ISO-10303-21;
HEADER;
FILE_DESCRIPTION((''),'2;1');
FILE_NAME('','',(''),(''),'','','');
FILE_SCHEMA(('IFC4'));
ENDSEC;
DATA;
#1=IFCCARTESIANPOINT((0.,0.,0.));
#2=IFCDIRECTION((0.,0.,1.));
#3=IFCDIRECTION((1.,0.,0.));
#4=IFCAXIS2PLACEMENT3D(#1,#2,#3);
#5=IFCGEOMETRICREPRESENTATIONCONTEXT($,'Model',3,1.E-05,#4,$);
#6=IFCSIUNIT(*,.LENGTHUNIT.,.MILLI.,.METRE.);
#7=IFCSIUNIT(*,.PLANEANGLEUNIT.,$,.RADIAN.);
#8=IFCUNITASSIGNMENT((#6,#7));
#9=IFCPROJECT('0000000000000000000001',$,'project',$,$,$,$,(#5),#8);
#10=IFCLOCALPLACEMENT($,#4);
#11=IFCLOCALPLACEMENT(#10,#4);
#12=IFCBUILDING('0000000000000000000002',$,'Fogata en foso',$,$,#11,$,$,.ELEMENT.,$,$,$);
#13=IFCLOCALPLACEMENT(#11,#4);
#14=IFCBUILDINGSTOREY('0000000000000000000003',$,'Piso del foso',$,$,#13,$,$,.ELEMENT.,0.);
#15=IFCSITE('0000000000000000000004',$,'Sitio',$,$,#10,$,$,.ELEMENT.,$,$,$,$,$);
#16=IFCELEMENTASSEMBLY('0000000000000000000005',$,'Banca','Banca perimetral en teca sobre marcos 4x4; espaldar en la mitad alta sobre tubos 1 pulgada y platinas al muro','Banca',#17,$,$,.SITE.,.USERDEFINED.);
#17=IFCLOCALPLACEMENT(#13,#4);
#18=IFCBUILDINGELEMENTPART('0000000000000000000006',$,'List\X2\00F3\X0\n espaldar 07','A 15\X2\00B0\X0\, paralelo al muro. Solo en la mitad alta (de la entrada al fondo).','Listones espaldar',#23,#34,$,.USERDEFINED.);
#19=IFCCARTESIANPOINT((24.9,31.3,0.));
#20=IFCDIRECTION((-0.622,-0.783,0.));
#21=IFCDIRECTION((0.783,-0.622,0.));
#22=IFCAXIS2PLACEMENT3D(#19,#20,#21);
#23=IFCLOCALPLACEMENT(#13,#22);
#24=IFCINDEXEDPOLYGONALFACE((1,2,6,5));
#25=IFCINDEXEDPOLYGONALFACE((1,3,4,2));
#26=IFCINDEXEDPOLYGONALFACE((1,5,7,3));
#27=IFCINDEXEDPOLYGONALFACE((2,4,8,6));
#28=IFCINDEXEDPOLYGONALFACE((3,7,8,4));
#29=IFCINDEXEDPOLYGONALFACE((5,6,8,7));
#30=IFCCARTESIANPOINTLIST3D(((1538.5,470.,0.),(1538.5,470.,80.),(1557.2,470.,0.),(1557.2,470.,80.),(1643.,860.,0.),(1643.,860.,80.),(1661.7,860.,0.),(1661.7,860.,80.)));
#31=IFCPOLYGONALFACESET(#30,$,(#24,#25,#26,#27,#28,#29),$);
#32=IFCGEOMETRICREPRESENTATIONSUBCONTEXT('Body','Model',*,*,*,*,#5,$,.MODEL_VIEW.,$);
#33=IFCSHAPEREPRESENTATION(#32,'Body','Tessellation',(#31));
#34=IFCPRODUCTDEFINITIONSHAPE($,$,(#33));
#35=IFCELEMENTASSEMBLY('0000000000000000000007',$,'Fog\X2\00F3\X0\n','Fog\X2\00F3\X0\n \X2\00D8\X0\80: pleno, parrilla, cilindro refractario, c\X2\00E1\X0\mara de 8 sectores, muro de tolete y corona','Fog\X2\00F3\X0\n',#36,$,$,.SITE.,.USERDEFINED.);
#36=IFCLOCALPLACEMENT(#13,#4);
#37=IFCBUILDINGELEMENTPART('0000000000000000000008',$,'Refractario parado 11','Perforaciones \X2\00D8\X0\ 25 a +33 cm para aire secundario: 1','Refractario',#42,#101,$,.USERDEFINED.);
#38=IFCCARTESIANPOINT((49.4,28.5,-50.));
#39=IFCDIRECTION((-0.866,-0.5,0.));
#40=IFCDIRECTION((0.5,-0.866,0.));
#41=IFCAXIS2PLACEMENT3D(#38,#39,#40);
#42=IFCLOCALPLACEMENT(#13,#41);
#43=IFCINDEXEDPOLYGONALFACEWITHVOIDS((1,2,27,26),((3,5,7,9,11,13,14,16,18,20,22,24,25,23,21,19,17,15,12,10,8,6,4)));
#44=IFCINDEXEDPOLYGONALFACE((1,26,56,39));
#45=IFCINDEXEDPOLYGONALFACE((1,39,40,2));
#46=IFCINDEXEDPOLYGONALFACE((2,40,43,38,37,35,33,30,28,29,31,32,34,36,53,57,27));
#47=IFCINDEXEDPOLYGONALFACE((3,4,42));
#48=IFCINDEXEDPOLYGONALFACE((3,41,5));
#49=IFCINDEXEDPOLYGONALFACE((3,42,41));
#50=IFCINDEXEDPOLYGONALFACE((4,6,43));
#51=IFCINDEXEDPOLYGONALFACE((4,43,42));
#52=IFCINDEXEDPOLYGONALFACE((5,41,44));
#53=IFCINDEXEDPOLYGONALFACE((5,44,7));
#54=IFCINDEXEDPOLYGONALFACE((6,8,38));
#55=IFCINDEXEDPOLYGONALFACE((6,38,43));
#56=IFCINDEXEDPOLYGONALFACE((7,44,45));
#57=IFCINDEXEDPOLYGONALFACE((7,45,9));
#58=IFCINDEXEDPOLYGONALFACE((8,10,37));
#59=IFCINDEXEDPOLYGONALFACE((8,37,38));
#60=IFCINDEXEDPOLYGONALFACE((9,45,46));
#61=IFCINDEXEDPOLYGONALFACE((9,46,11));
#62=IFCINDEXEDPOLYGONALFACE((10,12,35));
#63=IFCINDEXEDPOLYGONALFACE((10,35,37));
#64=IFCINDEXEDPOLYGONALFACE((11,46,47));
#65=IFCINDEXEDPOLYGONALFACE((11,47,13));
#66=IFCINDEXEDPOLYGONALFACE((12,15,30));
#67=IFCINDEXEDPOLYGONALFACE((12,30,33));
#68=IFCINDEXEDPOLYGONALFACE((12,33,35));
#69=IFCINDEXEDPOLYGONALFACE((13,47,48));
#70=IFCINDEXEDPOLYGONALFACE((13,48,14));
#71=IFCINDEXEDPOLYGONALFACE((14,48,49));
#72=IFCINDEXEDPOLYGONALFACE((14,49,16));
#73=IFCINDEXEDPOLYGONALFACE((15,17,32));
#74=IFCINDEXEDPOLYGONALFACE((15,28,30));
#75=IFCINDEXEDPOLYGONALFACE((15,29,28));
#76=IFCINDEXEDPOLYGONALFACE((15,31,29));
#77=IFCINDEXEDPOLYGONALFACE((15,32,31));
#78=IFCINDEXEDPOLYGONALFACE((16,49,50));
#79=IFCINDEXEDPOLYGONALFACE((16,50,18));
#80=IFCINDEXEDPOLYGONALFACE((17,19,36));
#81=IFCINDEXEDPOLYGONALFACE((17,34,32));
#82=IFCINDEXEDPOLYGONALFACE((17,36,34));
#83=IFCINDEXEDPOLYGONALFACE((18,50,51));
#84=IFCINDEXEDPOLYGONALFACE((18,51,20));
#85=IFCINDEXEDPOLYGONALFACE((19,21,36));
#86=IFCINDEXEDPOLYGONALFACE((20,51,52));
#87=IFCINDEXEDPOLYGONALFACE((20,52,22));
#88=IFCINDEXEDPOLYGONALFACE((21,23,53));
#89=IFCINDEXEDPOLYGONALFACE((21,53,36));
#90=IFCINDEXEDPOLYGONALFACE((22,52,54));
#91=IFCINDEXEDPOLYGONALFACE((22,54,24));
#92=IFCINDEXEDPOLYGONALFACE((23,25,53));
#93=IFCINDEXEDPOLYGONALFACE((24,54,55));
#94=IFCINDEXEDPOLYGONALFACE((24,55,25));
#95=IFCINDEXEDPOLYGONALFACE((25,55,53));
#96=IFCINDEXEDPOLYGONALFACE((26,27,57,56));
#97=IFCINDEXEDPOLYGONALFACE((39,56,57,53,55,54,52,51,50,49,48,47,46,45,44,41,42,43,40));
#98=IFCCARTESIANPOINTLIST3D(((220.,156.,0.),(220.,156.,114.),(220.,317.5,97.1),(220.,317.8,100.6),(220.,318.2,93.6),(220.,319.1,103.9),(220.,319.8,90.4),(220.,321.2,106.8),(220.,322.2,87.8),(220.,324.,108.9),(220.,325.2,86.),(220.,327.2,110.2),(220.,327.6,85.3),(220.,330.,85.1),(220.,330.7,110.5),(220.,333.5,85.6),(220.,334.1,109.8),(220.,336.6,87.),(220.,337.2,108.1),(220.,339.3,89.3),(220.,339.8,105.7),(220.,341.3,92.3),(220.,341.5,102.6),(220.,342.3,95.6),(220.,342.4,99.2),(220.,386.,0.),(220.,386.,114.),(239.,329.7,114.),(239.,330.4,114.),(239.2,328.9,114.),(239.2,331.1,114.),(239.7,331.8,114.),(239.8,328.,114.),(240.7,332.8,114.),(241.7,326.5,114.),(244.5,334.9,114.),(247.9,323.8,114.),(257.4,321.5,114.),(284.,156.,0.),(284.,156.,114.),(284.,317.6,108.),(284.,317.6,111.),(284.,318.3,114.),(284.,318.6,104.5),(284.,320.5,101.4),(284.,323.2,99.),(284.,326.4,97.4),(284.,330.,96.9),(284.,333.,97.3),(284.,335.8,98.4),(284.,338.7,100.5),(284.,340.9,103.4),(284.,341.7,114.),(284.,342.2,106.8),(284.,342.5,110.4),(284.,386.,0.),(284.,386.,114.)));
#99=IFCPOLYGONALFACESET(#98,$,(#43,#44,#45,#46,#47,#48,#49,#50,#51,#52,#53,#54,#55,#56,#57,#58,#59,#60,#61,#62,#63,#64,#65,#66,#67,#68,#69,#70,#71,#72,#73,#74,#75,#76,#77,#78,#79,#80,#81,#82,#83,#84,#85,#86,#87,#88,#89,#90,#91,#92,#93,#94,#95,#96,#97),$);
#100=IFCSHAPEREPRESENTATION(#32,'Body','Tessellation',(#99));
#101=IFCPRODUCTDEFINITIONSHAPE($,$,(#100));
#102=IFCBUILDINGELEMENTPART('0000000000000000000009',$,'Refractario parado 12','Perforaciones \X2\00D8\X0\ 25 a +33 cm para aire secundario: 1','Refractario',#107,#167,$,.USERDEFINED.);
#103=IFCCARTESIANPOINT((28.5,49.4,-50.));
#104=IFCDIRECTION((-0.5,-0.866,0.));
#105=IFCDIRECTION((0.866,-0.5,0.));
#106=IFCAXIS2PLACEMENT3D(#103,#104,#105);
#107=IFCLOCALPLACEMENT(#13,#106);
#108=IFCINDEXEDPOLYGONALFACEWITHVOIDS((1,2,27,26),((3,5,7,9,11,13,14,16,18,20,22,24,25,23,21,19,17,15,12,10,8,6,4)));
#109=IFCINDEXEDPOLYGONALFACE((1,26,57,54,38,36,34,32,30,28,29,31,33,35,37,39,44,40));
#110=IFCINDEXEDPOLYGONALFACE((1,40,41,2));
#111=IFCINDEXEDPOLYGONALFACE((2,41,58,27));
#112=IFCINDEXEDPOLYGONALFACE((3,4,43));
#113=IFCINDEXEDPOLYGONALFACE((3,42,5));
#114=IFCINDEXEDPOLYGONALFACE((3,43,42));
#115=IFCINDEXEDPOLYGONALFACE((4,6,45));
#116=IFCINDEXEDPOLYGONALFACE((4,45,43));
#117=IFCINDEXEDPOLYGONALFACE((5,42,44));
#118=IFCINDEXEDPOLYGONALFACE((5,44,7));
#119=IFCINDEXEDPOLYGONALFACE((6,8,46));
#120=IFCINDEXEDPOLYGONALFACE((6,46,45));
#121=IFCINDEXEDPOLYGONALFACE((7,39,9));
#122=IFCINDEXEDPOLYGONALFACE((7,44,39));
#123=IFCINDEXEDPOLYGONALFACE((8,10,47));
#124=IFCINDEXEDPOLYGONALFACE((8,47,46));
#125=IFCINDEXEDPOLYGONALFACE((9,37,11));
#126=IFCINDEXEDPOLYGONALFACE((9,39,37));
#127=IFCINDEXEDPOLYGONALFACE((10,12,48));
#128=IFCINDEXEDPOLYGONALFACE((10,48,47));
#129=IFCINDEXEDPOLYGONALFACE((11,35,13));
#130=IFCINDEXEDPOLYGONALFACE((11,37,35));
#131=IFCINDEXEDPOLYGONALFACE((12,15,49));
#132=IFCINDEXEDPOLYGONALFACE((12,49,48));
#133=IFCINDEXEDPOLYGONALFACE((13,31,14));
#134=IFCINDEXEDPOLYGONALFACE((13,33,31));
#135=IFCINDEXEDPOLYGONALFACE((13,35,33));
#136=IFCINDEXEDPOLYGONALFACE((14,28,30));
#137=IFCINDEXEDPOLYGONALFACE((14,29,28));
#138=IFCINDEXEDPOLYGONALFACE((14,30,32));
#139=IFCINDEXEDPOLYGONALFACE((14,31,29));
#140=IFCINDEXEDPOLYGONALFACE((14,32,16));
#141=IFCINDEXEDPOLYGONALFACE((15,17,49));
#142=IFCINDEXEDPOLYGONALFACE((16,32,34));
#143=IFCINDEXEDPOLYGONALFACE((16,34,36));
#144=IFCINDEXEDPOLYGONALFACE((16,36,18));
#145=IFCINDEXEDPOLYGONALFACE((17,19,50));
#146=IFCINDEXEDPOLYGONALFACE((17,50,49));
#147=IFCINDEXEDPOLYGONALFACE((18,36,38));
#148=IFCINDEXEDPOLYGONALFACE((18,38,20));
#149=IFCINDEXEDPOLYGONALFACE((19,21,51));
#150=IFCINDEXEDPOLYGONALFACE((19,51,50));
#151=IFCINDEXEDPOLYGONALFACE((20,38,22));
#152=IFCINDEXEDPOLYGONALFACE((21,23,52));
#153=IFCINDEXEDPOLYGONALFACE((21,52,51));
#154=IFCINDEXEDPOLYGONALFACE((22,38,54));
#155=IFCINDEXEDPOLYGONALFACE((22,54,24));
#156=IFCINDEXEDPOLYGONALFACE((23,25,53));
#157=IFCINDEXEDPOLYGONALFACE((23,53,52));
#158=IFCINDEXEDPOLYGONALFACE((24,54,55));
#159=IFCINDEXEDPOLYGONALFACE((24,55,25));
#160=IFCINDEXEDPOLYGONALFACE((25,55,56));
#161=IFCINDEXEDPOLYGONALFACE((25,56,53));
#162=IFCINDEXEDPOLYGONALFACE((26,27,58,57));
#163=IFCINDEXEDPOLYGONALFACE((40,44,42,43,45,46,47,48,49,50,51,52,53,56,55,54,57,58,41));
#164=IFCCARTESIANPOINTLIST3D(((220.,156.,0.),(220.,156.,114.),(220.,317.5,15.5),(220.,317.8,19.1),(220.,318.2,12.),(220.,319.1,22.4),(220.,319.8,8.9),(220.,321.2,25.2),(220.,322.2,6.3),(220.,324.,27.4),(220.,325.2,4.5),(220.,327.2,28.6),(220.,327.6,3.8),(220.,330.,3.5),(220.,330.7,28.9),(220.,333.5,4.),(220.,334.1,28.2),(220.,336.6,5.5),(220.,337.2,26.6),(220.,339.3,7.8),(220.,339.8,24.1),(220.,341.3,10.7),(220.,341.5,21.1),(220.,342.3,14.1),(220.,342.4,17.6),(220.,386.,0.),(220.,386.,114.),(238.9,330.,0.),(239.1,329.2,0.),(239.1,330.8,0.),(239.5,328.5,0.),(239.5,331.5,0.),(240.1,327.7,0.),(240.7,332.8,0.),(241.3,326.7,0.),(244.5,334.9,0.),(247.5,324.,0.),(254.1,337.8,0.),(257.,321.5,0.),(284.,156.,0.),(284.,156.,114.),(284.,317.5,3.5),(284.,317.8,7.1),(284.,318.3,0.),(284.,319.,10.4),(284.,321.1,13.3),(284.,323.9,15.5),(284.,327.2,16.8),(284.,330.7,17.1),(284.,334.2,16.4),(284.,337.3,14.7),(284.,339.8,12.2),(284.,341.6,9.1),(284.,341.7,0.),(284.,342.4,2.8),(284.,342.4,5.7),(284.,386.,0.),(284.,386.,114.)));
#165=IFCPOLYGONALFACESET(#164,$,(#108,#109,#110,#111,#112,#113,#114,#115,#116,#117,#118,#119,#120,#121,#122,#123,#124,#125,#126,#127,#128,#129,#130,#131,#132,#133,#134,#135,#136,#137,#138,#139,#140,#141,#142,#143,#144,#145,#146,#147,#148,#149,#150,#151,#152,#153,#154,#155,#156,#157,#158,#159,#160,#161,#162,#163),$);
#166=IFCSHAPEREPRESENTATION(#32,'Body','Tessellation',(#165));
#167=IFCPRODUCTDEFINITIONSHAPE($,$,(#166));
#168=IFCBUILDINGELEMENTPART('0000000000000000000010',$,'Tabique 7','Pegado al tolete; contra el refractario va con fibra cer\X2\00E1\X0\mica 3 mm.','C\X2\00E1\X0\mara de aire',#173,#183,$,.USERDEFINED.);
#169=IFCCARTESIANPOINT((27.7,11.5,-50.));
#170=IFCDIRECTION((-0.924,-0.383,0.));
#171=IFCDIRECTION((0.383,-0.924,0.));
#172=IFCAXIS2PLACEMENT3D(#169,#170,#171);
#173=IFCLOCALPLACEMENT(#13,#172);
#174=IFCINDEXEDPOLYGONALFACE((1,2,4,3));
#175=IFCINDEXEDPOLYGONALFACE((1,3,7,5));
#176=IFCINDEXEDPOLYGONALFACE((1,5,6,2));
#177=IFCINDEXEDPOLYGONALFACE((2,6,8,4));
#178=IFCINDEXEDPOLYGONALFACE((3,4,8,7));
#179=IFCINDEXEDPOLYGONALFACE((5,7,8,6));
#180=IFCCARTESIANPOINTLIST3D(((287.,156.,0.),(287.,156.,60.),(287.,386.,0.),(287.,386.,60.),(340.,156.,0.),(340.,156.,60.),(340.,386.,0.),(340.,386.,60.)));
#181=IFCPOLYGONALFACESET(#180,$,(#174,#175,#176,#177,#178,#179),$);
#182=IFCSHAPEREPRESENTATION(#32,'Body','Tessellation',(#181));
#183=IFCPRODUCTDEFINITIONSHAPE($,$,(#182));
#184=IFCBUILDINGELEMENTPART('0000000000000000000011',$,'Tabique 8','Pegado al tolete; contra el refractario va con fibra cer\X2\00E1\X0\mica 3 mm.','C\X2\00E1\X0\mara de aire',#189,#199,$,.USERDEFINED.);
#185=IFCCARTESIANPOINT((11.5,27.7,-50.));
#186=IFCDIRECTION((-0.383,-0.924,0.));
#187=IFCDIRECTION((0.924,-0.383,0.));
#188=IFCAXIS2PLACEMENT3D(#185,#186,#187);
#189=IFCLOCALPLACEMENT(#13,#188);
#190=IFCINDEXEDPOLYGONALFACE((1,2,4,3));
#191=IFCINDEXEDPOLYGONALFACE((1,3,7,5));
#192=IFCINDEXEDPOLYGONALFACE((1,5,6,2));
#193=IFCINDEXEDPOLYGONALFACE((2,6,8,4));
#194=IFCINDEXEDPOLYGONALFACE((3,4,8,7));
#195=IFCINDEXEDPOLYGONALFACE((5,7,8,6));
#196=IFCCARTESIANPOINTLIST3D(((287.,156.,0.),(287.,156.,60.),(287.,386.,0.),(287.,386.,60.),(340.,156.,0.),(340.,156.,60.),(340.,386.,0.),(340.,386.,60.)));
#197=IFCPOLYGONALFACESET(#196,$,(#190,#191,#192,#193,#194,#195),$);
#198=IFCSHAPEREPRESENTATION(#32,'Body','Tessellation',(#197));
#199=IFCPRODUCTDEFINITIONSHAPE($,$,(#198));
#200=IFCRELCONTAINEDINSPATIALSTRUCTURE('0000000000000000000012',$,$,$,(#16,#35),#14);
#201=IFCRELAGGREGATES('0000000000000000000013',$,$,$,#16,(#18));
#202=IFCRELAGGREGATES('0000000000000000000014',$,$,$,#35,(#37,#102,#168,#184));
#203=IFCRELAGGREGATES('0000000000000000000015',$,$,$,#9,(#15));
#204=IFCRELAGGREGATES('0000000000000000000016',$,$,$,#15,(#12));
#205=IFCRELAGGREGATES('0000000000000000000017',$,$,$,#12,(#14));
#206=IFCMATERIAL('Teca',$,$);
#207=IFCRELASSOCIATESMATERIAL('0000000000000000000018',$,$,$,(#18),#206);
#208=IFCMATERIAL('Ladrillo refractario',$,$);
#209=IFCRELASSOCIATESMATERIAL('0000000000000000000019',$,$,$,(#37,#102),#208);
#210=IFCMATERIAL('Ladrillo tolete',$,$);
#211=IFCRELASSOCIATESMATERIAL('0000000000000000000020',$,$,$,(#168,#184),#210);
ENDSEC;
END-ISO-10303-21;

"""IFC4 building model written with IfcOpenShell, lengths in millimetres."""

from ifc_helpers import new_model, si_unit, frame, origin_with_axes, origin_2d, place, context, subcontext, project, spatial, polyline, circle, outline, extrude, material, element, aggregate, save


model = new_model("IFC4")

# Units and contexts
model_context = context("Model", 3, precision=1e-05, world=origin_with_axes())
body_context = subcontext(model_context, "Body", "Model", "MODEL_VIEW")
ifc_project = project(units=[si_unit("LENGTHUNIT", "METRE", prefix="MILLI"), si_unit("PLANEANGLEUNIT", "RADIAN")], contexts=[model_context])

# Site, building, storey
site_placement = place(None, origin_with_axes())
site = spatial("IfcSite", under=ifc_project, at=site_placement, Name="Sitio", CompositionType="ELEMENT")
building_placement = place(site_placement, origin_with_axes())
building = spatial("IfcBuilding", under=site, at=building_placement, Name="Fogata en foso", CompositionType="ELEMENT")
storey_placement = place(building_placement, origin_with_axes())
storey = spatial("IfcBuildingStorey", under=building, at=storey_placement, Name="Piso del foso", CompositionType="ELEMENT", Elevation=0.0)

# Element assembly
assembly_1_placement = place(storey_placement, origin_with_axes())
assembly_1 = element("IfcElementAssembly", 1, at=assembly_1_placement, inside=storey, Name="Banca", Description="Banca perimetral en teca sobre marcos 4x4; espaldar en la mitad alta sobre tubos 1 pulgada y platinas al muro", ObjectType="Banca", AssemblyPlace="SITE", PredefinedType="USERDEFINED")

# Shared definitions
ifc_material_1 = material(Name="Teca")

# Building element part
building_element_part_1_placement = place(storey_placement, frame((24.9, 31.3, 0.0), z_axis=(-0.622, -0.783, 0.0), x_axis=(0.783, -0.622, 0.0)))
building_element_part_1 = element("IfcBuildingElementPart", 2, at=building_element_part_1_placement, material=ifc_material_1, Name="Listón espaldar 07", Description="A 15°, paralelo al muro. Solo en la mitad alta (de la entrada al fondo).", ObjectType="Listones espaldar", PredefinedType="USERDEFINED", context=body_context, shape_type="SweptSolid", body=[
    extrude(outline(polyline([(1538.5, 470.0), (1557.2, 470.0), (1661.7, 860.0), (1643.0, 860.0), (1538.5, 470.0)])), origin_with_axes(), (0.0, 0.0, 1.0), 80.0),
])
aggregate(assembly_1, [building_element_part_1])

# Element assembly, building element parts, openings
assembly_2_placement = place(storey_placement, origin_with_axes())
assembly_2 = element("IfcElementAssembly", 3, at=assembly_2_placement, inside=storey, Name="Fogón", Description="Fogón Ø80: pleno, parrilla, cilindro refractario, cámara de 8 sectores, muro de tolete y corona", ObjectType="Fogón", AssemblyPlace="SITE", PredefinedType="USERDEFINED")
ifc_material_2 = material(Name="Ladrillo refractario")
building_element_part_2_placement = place(storey_placement, frame((49.4, 28.5, -50.0), z_axis=(-0.866, -0.5, 0.0), x_axis=(0.5, -0.866, 0.0)))
building_element_part_2 = element("IfcBuildingElementPart", 4, at=building_element_part_2_placement, material=ifc_material_2, Name="Refractario parado 11", Description="Perforaciones Ø 25 a +33 cm para aire secundario: 1", ObjectType="Refractario", PredefinedType="USERDEFINED", context=body_context, shape_type="SweptSolid", body=[
    extrude(outline(polyline([(220.0, 156.0), (284.0, 156.0), (284.0, 386.0), (220.0, 386.0), (220.0, 156.0)])), origin_with_axes(), (0.0, 0.0, 1.0), 114.0),
])
opening_1_placement = place(storey_placement, frame((65.1, -183.8, 280.0), z_axis=(0.334, -0.943, 0.0), x_axis=(0.943, 0.334, 0.0)))
element("IfcOpeningElement", 5, at=opening_1_placement, cuts=building_element_part_2, PredefinedType="OPENING", context=body_context, shape_type="SweptSolid", body=[
    extrude(circle(Radius=12.5, at=origin_2d()), origin_with_axes(), (0.0, 0.0, 1.0), 110.0),
])
building_element_part_3_placement = place(storey_placement, frame((28.5, 49.4, -50.0), z_axis=(-0.5, -0.866, 0.0), x_axis=(0.866, -0.5, 0.0)))
building_element_part_3 = element("IfcBuildingElementPart", 6, at=building_element_part_3_placement, material=ifc_material_2, Name="Refractario parado 12", Description="Perforaciones Ø 25 a +33 cm para aire secundario: 1", ObjectType="Refractario", PredefinedType="USERDEFINED", context=body_context, shape_type="SweptSolid", body=[
    extrude(outline(polyline([(220.0, 156.0), (284.0, 156.0), (284.0, 386.0), (220.0, 386.0), (220.0, 156.0)])), origin_with_axes(), (0.0, 0.0, 1.0), 114.0),
])
opening_2_placement = place(storey_placement, frame((183.8, -65.1, 280.0), z_axis=(0.943, -0.334, 0.0), x_axis=(0.334, 0.943, 0.0)))
element("IfcOpeningElement", 7, at=opening_2_placement, cuts=building_element_part_3, PredefinedType="OPENING", context=body_context, shape_type="SweptSolid", body=[
    extrude(circle(Radius=12.5, at=origin_2d()), origin_with_axes(), (0.0, 0.0, 1.0), 110.0),
])
ifc_material_3 = material(Name="Ladrillo tolete")
building_element_part_4_placement = place(storey_placement, frame((27.7, 11.5, -50.0), z_axis=(-0.924, -0.383, 0.0), x_axis=(0.383, -0.924, 0.0)))
building_element_part_4 = element("IfcBuildingElementPart", 8, at=building_element_part_4_placement, material=ifc_material_3, Name="Tabique 7", Description="Pegado al tolete; contra el refractario va con fibra cerámica 3 mm.", ObjectType="Cámara de aire", PredefinedType="USERDEFINED", context=body_context, shape_type="SweptSolid", body=[
    extrude(outline(polyline([(287.0, 156.0), (340.0, 156.0), (340.0, 386.0), (287.0, 386.0), (287.0, 156.0)])), origin_with_axes(), (0.0, 0.0, 1.0), 60.0),
])
building_element_part_5_placement = place(storey_placement, frame((11.5, 27.7, -50.0), z_axis=(-0.383, -0.924, 0.0), x_axis=(0.924, -0.383, 0.0)))
building_element_part_5 = element("IfcBuildingElementPart", 9, at=building_element_part_5_placement, material=ifc_material_3, Name="Tabique 8", Description="Pegado al tolete; contra el refractario va con fibra cerámica 3 mm.", ObjectType="Cámara de aire", PredefinedType="USERDEFINED", context=body_context, shape_type="SweptSolid", body=[
    extrude(outline(polyline([(287.0, 156.0), (340.0, 156.0), (340.0, 386.0), (287.0, 386.0), (287.0, 156.0)])), origin_with_axes(), (0.0, 0.0, 1.0), 60.0),
])
aggregate(assembly_2, [building_element_part_2, building_element_part_3, building_element_part_4, building_element_part_5])

save(model, "model.ifc")
